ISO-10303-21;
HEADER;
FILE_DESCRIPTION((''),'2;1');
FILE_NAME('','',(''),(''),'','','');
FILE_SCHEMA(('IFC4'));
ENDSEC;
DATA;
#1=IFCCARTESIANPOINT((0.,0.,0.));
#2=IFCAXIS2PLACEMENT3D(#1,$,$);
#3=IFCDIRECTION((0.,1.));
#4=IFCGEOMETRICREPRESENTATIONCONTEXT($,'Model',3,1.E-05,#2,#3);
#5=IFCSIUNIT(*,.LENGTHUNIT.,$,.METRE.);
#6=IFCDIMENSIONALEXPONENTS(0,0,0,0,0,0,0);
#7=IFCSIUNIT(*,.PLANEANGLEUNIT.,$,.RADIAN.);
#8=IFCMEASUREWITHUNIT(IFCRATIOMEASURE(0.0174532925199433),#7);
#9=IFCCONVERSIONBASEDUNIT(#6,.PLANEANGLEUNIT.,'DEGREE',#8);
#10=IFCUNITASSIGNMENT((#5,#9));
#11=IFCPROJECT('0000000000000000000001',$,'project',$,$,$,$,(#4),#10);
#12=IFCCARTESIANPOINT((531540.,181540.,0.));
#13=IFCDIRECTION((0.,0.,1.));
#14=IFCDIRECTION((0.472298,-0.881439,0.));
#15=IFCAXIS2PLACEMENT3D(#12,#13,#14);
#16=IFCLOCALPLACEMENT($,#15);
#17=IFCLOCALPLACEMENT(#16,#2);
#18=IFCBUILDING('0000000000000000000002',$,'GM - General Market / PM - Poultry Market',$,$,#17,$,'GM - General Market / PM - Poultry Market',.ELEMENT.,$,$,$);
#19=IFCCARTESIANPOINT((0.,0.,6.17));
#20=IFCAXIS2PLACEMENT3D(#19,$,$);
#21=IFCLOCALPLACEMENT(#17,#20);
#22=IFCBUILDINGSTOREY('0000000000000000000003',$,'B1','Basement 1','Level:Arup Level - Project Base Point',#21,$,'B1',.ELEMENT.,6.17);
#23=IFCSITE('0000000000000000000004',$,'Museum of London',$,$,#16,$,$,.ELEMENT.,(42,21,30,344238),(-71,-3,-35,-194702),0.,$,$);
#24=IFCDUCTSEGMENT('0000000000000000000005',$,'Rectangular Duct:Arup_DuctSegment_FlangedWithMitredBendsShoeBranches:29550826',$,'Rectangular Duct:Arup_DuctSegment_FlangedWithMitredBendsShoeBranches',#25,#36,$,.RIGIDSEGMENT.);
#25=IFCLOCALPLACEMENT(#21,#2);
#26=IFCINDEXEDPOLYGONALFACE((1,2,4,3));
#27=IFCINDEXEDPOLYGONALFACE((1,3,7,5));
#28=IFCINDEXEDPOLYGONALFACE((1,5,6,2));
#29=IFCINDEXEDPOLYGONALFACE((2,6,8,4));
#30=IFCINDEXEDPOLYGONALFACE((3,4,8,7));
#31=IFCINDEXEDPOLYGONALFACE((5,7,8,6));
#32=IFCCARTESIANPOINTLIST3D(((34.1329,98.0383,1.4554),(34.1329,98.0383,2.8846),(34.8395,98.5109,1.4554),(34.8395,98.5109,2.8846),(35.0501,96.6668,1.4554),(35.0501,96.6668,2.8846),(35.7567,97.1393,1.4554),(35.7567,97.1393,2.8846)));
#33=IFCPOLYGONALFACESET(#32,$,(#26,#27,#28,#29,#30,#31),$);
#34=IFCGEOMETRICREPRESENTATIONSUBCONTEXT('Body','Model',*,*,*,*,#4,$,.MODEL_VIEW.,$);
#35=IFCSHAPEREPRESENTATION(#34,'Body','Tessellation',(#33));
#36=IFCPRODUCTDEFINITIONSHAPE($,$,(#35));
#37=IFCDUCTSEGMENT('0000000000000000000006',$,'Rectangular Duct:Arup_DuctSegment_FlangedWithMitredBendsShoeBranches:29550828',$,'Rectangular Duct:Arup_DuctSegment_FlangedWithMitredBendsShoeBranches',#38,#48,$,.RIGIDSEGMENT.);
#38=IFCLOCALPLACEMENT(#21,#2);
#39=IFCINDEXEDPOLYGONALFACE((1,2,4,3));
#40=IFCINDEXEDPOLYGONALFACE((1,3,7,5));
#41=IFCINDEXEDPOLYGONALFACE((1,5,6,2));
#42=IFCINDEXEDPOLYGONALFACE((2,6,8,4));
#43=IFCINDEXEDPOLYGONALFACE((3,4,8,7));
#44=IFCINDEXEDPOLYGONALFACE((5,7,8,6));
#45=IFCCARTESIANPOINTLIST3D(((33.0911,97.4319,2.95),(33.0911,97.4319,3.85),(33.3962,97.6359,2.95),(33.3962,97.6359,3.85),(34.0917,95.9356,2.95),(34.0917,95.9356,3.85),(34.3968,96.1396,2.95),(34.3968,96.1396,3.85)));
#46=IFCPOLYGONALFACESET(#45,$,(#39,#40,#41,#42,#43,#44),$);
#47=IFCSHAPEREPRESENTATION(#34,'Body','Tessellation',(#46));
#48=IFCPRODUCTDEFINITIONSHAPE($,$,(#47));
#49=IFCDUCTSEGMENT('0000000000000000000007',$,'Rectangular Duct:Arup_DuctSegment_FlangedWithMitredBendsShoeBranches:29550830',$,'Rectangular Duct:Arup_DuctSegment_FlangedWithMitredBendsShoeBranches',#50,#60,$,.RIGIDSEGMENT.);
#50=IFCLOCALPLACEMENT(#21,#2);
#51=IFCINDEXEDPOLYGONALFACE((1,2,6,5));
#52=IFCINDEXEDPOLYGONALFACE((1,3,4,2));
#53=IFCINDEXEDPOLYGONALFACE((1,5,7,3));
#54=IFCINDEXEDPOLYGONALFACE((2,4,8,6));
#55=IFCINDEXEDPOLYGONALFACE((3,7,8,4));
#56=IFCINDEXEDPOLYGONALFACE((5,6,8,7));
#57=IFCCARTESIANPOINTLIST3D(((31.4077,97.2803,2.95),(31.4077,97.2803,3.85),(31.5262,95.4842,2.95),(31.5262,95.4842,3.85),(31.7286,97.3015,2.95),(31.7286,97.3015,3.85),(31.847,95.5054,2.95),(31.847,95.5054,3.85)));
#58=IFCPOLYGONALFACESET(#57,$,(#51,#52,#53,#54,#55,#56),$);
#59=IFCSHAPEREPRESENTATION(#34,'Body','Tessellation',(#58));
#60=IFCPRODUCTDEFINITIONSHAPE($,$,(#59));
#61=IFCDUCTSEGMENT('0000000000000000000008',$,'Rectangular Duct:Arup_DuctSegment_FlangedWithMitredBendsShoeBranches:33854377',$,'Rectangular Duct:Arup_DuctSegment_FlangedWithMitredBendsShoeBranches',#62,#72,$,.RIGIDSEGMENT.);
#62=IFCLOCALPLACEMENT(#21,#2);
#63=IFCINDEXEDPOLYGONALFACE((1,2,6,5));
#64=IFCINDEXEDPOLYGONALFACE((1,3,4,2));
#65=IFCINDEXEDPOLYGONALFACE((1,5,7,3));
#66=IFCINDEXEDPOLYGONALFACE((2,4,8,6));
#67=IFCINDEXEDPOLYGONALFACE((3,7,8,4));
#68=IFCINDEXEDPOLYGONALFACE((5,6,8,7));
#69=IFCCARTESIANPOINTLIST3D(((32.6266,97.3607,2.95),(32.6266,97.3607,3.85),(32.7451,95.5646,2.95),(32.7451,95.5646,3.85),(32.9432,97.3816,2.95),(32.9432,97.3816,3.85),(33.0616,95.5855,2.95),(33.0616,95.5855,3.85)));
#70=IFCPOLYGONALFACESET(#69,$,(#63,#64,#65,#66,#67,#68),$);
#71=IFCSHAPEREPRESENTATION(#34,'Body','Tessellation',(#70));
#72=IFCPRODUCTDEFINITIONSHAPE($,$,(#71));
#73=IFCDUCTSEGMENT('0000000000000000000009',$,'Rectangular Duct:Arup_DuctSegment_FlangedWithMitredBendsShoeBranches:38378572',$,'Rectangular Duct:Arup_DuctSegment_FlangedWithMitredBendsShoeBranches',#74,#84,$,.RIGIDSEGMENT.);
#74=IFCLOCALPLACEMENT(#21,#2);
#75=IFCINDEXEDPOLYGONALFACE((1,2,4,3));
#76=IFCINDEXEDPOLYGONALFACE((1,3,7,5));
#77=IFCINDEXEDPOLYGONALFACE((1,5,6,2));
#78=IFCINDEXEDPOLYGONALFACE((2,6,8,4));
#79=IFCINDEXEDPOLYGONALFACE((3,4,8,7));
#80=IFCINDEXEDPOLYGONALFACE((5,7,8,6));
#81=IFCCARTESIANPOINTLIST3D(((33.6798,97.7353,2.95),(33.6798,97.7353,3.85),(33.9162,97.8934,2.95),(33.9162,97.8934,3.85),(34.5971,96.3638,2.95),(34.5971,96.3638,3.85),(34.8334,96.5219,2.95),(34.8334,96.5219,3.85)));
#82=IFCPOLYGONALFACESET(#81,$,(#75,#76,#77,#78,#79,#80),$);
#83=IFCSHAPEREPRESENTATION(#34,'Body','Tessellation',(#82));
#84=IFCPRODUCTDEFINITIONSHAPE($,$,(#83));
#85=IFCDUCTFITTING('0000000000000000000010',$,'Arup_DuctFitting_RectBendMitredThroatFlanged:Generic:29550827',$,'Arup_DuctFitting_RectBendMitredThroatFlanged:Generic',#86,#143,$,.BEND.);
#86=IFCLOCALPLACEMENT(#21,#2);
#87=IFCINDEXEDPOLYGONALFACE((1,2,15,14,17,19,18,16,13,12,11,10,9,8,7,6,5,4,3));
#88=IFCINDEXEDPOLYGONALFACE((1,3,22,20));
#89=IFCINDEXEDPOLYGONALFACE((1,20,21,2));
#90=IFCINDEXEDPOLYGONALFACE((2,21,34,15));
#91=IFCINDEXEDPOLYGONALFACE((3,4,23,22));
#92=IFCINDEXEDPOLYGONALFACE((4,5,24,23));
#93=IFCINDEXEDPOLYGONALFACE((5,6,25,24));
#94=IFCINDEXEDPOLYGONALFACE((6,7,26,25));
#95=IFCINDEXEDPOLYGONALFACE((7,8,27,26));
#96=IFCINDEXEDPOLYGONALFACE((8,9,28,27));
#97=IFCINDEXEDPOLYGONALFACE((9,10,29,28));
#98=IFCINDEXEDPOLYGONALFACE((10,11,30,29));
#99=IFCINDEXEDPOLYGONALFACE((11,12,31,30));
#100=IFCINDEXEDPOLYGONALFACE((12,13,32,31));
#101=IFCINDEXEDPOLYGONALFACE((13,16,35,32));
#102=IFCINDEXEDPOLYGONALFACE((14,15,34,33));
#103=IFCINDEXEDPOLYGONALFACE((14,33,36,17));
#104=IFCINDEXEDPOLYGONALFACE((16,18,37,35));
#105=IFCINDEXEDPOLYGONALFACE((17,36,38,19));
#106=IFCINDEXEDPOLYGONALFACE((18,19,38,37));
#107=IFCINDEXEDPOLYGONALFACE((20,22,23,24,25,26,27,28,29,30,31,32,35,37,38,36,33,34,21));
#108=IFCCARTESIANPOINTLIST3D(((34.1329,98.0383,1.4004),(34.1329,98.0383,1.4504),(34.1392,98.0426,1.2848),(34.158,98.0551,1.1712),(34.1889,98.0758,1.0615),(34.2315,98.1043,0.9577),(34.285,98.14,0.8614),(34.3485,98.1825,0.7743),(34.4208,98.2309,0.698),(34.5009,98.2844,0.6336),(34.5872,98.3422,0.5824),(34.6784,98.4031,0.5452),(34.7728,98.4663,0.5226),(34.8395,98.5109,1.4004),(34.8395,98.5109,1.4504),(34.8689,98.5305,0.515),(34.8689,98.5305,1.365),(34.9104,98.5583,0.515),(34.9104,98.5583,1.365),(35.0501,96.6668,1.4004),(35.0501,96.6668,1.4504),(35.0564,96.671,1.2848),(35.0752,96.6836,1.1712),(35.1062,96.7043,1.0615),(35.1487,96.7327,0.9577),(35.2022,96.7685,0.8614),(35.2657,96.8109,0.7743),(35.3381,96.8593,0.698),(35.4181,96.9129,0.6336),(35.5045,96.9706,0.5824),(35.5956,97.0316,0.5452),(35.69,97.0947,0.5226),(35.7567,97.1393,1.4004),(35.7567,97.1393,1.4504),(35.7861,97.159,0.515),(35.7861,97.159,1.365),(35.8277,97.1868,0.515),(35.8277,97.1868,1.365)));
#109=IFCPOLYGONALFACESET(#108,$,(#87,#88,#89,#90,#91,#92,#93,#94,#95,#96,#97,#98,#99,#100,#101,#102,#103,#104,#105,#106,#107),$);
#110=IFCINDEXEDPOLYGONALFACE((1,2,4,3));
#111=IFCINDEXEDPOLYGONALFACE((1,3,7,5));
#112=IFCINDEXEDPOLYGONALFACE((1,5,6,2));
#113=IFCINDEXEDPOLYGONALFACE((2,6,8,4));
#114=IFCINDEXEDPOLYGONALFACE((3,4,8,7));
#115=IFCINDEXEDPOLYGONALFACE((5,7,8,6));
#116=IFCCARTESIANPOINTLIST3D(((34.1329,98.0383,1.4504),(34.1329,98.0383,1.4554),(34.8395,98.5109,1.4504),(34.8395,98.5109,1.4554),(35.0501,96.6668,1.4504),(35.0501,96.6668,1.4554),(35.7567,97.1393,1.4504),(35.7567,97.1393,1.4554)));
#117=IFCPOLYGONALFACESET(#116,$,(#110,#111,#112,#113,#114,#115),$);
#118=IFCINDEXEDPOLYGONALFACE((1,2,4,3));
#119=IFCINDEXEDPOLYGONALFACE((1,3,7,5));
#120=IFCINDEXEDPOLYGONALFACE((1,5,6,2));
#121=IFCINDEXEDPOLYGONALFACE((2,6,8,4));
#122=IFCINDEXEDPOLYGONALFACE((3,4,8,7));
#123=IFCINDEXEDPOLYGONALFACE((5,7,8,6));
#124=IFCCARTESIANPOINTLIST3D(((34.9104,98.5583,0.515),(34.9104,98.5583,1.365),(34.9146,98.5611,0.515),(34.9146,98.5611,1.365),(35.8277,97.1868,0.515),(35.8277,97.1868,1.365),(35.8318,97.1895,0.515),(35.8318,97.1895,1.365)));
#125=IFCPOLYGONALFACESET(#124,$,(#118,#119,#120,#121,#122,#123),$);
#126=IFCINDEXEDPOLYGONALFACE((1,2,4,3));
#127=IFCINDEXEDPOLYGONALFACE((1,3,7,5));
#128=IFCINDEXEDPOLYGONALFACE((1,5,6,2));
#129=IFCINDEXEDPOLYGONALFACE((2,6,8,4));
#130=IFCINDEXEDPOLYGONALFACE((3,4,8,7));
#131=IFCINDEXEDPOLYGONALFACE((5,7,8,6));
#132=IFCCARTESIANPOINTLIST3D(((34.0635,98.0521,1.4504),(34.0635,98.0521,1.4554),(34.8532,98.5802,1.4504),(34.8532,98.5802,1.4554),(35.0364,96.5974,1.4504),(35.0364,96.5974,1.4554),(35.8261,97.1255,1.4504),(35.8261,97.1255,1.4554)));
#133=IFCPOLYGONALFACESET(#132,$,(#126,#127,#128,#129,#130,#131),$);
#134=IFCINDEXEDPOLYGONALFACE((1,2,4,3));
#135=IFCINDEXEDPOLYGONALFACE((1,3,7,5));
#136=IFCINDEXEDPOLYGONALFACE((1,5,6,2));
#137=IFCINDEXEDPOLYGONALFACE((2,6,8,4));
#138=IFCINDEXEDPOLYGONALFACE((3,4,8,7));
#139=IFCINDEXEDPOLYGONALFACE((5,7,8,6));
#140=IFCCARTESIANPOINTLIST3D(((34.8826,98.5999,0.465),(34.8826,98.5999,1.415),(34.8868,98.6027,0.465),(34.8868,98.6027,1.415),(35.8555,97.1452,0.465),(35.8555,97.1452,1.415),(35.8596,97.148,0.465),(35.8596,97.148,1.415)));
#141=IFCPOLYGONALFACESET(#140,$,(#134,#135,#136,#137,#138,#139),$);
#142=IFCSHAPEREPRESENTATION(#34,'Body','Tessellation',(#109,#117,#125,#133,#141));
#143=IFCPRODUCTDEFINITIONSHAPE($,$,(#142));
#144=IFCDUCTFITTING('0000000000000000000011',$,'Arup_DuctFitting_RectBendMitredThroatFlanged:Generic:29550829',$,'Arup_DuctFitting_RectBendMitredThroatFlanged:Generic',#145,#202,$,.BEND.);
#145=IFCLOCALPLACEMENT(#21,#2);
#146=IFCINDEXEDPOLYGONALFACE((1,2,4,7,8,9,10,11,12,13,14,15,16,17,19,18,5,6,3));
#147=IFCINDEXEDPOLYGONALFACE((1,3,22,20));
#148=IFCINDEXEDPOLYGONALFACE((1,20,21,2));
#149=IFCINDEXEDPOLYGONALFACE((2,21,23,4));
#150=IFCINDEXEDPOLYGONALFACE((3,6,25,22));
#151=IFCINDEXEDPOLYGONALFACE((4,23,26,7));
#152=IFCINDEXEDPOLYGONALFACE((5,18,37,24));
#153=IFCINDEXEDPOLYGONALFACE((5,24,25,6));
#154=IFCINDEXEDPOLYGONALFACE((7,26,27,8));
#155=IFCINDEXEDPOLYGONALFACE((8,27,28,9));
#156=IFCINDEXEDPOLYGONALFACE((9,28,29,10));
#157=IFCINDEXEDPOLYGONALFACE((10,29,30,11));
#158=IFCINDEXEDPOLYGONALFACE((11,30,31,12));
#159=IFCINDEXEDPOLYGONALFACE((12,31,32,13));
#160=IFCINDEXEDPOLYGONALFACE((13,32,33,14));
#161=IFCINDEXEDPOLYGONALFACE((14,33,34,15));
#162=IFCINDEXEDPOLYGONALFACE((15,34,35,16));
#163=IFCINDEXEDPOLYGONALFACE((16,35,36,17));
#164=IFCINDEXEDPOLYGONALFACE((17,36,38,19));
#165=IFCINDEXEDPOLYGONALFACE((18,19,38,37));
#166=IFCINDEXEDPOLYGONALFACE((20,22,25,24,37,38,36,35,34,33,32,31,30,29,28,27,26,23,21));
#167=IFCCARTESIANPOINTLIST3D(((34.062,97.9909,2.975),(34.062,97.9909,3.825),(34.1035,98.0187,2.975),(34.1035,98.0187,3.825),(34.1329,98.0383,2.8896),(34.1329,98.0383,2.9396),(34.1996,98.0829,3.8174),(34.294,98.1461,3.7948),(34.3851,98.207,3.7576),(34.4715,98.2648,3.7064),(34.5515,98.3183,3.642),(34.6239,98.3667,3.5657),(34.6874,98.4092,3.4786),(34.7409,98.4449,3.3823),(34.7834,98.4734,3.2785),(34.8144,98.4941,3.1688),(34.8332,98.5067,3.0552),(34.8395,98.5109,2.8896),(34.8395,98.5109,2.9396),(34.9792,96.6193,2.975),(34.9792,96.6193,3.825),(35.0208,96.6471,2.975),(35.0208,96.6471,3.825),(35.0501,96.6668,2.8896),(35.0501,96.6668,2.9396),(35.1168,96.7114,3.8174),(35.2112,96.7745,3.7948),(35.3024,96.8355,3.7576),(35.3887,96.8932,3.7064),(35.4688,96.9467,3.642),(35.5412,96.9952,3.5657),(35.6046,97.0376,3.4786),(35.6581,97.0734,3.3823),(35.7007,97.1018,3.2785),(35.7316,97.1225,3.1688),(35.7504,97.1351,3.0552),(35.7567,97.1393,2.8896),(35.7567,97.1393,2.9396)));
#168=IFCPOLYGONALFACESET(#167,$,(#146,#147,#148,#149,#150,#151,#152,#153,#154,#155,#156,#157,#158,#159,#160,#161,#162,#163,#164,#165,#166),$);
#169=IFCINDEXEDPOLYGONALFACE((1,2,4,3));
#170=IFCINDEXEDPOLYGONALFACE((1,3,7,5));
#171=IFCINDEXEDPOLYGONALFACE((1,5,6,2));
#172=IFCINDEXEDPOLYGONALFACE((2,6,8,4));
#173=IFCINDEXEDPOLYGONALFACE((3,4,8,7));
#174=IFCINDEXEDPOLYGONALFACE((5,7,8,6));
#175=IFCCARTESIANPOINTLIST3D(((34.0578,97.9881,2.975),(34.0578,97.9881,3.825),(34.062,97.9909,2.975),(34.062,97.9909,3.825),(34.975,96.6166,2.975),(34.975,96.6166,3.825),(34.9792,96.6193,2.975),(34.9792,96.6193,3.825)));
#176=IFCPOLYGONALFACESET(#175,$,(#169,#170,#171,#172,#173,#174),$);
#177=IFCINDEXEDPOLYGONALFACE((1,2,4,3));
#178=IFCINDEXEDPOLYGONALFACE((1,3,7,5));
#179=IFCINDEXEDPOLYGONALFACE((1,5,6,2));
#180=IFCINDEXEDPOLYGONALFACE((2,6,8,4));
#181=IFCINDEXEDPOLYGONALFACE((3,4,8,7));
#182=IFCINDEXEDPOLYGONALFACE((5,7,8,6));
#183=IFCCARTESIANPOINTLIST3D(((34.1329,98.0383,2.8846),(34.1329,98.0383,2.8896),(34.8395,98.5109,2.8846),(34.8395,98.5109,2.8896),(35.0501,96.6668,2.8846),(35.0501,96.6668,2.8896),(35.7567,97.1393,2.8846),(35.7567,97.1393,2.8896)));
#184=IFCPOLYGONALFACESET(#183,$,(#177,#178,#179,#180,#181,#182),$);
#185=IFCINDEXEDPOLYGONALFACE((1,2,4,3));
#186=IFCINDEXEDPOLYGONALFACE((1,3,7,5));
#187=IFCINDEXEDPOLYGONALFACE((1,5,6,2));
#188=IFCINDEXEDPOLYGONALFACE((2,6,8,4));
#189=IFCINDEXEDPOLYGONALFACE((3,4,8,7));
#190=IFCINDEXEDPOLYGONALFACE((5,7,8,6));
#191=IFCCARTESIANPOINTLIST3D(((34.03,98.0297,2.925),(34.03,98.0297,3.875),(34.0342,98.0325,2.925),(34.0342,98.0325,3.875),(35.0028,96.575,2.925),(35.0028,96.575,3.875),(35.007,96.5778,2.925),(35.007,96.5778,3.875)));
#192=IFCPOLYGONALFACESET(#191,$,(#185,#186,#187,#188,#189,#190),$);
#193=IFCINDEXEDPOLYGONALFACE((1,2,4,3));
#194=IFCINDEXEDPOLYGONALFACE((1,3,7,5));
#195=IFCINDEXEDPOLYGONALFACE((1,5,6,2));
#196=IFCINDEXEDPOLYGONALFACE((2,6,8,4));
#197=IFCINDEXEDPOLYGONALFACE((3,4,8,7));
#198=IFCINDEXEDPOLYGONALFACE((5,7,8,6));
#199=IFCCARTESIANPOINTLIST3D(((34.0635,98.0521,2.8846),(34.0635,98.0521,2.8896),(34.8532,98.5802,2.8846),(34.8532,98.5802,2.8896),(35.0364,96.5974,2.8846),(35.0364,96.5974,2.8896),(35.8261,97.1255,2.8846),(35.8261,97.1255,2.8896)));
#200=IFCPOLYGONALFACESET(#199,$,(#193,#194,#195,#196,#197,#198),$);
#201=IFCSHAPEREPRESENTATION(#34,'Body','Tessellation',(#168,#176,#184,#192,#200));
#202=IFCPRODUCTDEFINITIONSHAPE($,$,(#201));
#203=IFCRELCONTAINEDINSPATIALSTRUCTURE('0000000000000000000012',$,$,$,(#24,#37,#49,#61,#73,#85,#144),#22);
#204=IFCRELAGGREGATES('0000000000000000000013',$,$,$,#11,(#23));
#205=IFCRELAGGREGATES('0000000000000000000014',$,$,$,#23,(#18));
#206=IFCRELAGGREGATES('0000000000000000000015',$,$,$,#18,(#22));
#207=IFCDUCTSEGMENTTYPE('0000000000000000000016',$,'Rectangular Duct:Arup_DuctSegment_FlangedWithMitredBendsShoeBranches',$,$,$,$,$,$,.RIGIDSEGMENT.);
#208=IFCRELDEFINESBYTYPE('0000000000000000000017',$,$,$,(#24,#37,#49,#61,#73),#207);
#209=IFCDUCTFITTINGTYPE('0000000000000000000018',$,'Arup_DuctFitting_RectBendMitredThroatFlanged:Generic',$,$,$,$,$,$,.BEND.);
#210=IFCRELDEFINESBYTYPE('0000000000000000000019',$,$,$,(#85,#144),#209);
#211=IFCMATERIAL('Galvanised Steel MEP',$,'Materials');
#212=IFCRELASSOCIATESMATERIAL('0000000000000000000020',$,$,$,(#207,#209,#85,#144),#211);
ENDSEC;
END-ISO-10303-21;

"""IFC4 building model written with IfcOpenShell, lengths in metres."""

from ifc_helpers import new_model, entity, si_unit, converted_unit, direction, frame, frame_2d, origin, origin_2d_with_axis, place, context, subcontext, project, spatial, polyline, circle_curve, parameter, trimmed, segment, composite_curve, rectangle, outline, extrude, source, transform, mapped, material, type_object, type_shapes, element, save


model = new_model("IFC4")

# Units and contexts
model_context = context("Model", 3, precision=1e-05, world=origin(), true_north=direction((0.0, 1.0)))
body_context = subcontext(model_context, "Body", "Model", "MODEL_VIEW")
ifc_project = project(units=[si_unit("LENGTHUNIT", "METRE"), converted_unit("PLANEANGLEUNIT", "DEGREE", entity("IfcRatioMeasure", 0.0174532925199433), si_unit("PLANEANGLEUNIT", "RADIAN"), dimensions=[0, 0, 0, 0, 0, 0, 0])], contexts=[model_context])

# Site, building, storey
site_placement = place(None, frame((531540.0, 181540.0, 0.0), z_axis=(0.0, 0.0, 1.0), x_axis=(0.472298, -0.881439, 0.0)))
site = spatial("IfcSite", under=ifc_project, at=site_placement, Name="Museum of London", CompositionType="ELEMENT", RefLatitude=(42, 21, 30, 344238), RefLongitude=(-71, -3, -35, -194702), RefElevation=0.0)
building_placement = place(site_placement, origin())
building = spatial("IfcBuilding", under=site, at=building_placement, Name="GM - General Market / PM - Poultry Market", LongName="GM - General Market / PM - Poultry Market", CompositionType="ELEMENT")
storey_placement = place(building_placement, frame((0.0, 0.0, 6.17)))
storey = spatial("IfcBuildingStorey", under=building, at=storey_placement, Name="B1", Description="Basement 1", ObjectType="Level:Arup Level - Project Base Point", LongName="B1", CompositionType="ELEMENT", Elevation=6.17)

# Duct segments
ifc_material_1 = material(Name="Galvanised Steel MEP", Category="Materials")
duct_segment_type = type_object("IfcDuctSegmentType", Name="Rectangular Duct:Arup_DuctSegment_FlangedWithMitredBendsShoeBranches", PredefinedType="RIGIDSEGMENT", material=ifc_material_1)
duct_segment_1_placement = place(storey_placement, frame((34.1329, 96.6668, 1.4554)))
element("IfcDuctSegment", 1, at=duct_segment_1_placement, inside=storey, type_object=duct_segment_type, Name="Rectangular Duct:Arup_DuctSegment_FlangedWithMitredBendsShoeBranches:29550826", ObjectType="Rectangular Duct:Arup_DuctSegment_FlangedWithMitredBendsShoeBranches", PredefinedType="RIGIDSEGMENT", context=body_context, shape_type="SweptSolid", body=[
    extrude(rectangle(XDim=0.85, YDim=1.65, at=origin_2d_with_axis()), frame((0.8119, 0.922, 0.0), z_axis=(0.0, 0.0, 1.0), x_axis=(-0.831246, -0.555905, 0.0)), (0.0, 0.0, 1.0), 1.4293),
])
duct_segment_2_placement = place(storey_placement, frame((33.0911, 95.9356, 2.95)))
element("IfcDuctSegment", 2, at=duct_segment_2_placement, inside=storey, type_object=duct_segment_type, Name="Rectangular Duct:Arup_DuctSegment_FlangedWithMitredBendsShoeBranches:29550828", ObjectType="Rectangular Duct:Arup_DuctSegment_FlangedWithMitredBendsShoeBranches", PredefinedType="RIGIDSEGMENT", context=body_context, shape_type="SweptSolid", body=[
    extrude(rectangle(XDim=0.367, YDim=1.8, at=origin_2d_with_axis()), frame((0.6528, 0.8501, 0.0), z_axis=(0.0, 0.0, 1.0), x_axis=(-0.831246, -0.555905, 0.0)), (0.0, 0.0, 1.0), 0.9),
])
duct_segment_3_placement = place(storey_placement, frame((31.4077, 95.4842, 2.95)))
element("IfcDuctSegment", 3, at=duct_segment_3_placement, inside=storey, type_object=duct_segment_type, Name="Rectangular Duct:Arup_DuctSegment_FlangedWithMitredBendsShoeBranches:29550830", ObjectType="Rectangular Duct:Arup_DuctSegment_FlangedWithMitredBendsShoeBranches", PredefinedType="RIGIDSEGMENT", context=body_context, shape_type="SweptSolid", body=[
    extrude(rectangle(XDim=0.3215, YDim=1.8, at=origin_2d_with_axis()), frame((0.2196, 0.9086, 0.0), z_axis=(0.0, 0.0, 1.0), x_axis=(-0.997833, -0.065805, 0.0)), (0.0, 0.0, 1.0), 0.9),
])
duct_segment_4_placement = place(storey_placement, frame((32.6266, 95.5646, 2.95)))
element("IfcDuctSegment", 4, at=duct_segment_4_placement, inside=storey, type_object=duct_segment_type, Name="Rectangular Duct:Arup_DuctSegment_FlangedWithMitredBendsShoeBranches:33854377", ObjectType="Rectangular Duct:Arup_DuctSegment_FlangedWithMitredBendsShoeBranches", PredefinedType="RIGIDSEGMENT", context=body_context, shape_type="SweptSolid", body=[
    extrude(rectangle(XDim=0.3172, YDim=1.8, at=origin_2d_with_axis()), frame((0.2175, 0.9085, 0.0), z_axis=(0.0, 0.0, 1.0), x_axis=(-0.997833, -0.065805, 0.0)), (0.0, 0.0, 1.0), 0.9),
])
duct_segment_5_placement = place(storey_placement, frame((33.6798, 96.3638, 2.95)))
element("IfcDuctSegment", 5, at=duct_segment_5_placement, inside=storey, type_object=duct_segment_type, Name="Rectangular Duct:Arup_DuctSegment_FlangedWithMitredBendsShoeBranches:38378572", ObjectType="Rectangular Duct:Arup_DuctSegment_FlangedWithMitredBendsShoeBranches", PredefinedType="RIGIDSEGMENT", context=body_context, shape_type="SweptSolid", body=[
    extrude(rectangle(XDim=0.2844, YDim=1.65, at=frame_2d((0.0, 0.0), x_axis=(1.0, 0.0))), frame((0.5768, 0.7648, 0.0), z_axis=(0.0, 0.0, 1.0), x_axis=(-0.831246, -0.555905, 0.0)), (0.0, 0.0, 1.0), 0.9),
])

# Duct fittings
duct_fitting_type_1 = type_object("IfcDuctFittingType", Name="Arup_DuctFitting_RectBendMitredThroatFlanged:Generic", PredefinedType="BEND", material=ifc_material_1)
shared_shape_1 = source(origin(), body_context, "Body", "SweptSolid", [
    extrude(outline(composite_curve([segment(polyline([(0.2177, -0.1823), (0.2677, -0.1823)]), True, "CONTINUOUS"), segment(polyline([(0.2677, -0.1823), (0.2677, 0.6677)]), True, "CONTINUOUS"), segment(polyline([(0.2677, 0.6677), (0.2177, 0.6677)]), True, "CONTINUOUS"), segment(trimmed(circle_curve(frame_2d((0.2177, -0.2177), x_axis=(-1.0, 0.0)), 0.8854), [parameter(270.0)], [parameter(0.0)], True, "PARAMETER"), True, "CONTINUOUS"), segment(polyline([(-0.6677, -0.2177), (-0.6677, -0.2677)]), True, "CONTINUOUS"), segment(polyline([(-0.6677, -0.2677), (0.1823, -0.2677)]), True, "CONTINUOUS"), segment(polyline([(0.1823, -0.2677), (0.1823, -0.2177)]), True, "CONTINUOUS"), segment(polyline([(0.1823, -0.2177), (0.2177, -0.1823)]), True, "CONTINUOUS")], self_intersect=False)), frame((-0.2427, 0.2427, -0.825), z_axis=(0.0, 0.0, 1.0), x_axis=(-1.0, 0.0, 0.0)), (0.0, 0.0, 1.0), 1.65),
    extrude(rectangle(XDim=0.005, YDim=0.85, at=frame_2d((0.0, 0.0), x_axis=(1.0, 0.0))), frame((0.0, 0.5129, -0.825), z_axis=(0.0, 0.0, 1.0), x_axis=(0.0, 1.0, 0.0)), (0.0, 0.0, 1.0), 1.65),
    extrude(rectangle(XDim=0.005, YDim=0.85, at=origin_2d_with_axis()), frame((-0.5129, 0.0, -0.825), z_axis=(0.0, 0.0, 1.0), x_axis=(-1.0, 0.0, 0.0)), (0.0, 0.0, 1.0), 1.65),
    extrude(rectangle(XDim=0.005, YDim=0.95, at=frame_2d((0.0, 0.0), x_axis=(1.0, 0.0))), frame((0.0, 0.5129, -0.875), z_axis=(0.0, 0.0, 1.0), x_axis=(0.0, 1.0, 0.0)), (0.0, 0.0, 1.0), 1.75),
    extrude(rectangle(XDim=0.005, YDim=0.95, at=origin_2d_with_axis()), frame((-0.5129, 0.0, -0.875), z_axis=(0.0, 0.0, 1.0), x_axis=(-1.0, 0.0, 0.0)), (0.0, 0.0, 1.0), 1.75),
])
type_shapes(duct_fitting_type_1, [shared_shape_1])
for number, where, z_axis, x_axis, name in (
    (6, (34.9448, 97.5888, 0.94), (-0.555905, 0.831246, 0.0), (-0.831246, -0.555905, 0.0), "Arup_DuctFitting_RectBendMitredThroatFlanged:Generic:29550827"),
    (7, (34.9448, 97.5888, 3.4), (0.555905, -0.831246, 0.0), (0.0, 0.0, 1.0), "Arup_DuctFitting_RectBendMitredThroatFlanged:Generic:29550829"),
):
    element("IfcDuctFitting", number, at=place(storey_placement, frame(where, z_axis=z_axis, x_axis=x_axis)), inside=storey, type_object=duct_fitting_type_1, material=ifc_material_1, Name=name, ObjectType="Arup_DuctFitting_RectBendMitredThroatFlanged:Generic", PredefinedType="BEND", context=body_context, shape_type="MappedRepresentation", body=[
        mapped(shared_shape_1, transform((0.0, 0.0, 0.0), scale=1.0)),
    ])

save(model, "model.ifc")
